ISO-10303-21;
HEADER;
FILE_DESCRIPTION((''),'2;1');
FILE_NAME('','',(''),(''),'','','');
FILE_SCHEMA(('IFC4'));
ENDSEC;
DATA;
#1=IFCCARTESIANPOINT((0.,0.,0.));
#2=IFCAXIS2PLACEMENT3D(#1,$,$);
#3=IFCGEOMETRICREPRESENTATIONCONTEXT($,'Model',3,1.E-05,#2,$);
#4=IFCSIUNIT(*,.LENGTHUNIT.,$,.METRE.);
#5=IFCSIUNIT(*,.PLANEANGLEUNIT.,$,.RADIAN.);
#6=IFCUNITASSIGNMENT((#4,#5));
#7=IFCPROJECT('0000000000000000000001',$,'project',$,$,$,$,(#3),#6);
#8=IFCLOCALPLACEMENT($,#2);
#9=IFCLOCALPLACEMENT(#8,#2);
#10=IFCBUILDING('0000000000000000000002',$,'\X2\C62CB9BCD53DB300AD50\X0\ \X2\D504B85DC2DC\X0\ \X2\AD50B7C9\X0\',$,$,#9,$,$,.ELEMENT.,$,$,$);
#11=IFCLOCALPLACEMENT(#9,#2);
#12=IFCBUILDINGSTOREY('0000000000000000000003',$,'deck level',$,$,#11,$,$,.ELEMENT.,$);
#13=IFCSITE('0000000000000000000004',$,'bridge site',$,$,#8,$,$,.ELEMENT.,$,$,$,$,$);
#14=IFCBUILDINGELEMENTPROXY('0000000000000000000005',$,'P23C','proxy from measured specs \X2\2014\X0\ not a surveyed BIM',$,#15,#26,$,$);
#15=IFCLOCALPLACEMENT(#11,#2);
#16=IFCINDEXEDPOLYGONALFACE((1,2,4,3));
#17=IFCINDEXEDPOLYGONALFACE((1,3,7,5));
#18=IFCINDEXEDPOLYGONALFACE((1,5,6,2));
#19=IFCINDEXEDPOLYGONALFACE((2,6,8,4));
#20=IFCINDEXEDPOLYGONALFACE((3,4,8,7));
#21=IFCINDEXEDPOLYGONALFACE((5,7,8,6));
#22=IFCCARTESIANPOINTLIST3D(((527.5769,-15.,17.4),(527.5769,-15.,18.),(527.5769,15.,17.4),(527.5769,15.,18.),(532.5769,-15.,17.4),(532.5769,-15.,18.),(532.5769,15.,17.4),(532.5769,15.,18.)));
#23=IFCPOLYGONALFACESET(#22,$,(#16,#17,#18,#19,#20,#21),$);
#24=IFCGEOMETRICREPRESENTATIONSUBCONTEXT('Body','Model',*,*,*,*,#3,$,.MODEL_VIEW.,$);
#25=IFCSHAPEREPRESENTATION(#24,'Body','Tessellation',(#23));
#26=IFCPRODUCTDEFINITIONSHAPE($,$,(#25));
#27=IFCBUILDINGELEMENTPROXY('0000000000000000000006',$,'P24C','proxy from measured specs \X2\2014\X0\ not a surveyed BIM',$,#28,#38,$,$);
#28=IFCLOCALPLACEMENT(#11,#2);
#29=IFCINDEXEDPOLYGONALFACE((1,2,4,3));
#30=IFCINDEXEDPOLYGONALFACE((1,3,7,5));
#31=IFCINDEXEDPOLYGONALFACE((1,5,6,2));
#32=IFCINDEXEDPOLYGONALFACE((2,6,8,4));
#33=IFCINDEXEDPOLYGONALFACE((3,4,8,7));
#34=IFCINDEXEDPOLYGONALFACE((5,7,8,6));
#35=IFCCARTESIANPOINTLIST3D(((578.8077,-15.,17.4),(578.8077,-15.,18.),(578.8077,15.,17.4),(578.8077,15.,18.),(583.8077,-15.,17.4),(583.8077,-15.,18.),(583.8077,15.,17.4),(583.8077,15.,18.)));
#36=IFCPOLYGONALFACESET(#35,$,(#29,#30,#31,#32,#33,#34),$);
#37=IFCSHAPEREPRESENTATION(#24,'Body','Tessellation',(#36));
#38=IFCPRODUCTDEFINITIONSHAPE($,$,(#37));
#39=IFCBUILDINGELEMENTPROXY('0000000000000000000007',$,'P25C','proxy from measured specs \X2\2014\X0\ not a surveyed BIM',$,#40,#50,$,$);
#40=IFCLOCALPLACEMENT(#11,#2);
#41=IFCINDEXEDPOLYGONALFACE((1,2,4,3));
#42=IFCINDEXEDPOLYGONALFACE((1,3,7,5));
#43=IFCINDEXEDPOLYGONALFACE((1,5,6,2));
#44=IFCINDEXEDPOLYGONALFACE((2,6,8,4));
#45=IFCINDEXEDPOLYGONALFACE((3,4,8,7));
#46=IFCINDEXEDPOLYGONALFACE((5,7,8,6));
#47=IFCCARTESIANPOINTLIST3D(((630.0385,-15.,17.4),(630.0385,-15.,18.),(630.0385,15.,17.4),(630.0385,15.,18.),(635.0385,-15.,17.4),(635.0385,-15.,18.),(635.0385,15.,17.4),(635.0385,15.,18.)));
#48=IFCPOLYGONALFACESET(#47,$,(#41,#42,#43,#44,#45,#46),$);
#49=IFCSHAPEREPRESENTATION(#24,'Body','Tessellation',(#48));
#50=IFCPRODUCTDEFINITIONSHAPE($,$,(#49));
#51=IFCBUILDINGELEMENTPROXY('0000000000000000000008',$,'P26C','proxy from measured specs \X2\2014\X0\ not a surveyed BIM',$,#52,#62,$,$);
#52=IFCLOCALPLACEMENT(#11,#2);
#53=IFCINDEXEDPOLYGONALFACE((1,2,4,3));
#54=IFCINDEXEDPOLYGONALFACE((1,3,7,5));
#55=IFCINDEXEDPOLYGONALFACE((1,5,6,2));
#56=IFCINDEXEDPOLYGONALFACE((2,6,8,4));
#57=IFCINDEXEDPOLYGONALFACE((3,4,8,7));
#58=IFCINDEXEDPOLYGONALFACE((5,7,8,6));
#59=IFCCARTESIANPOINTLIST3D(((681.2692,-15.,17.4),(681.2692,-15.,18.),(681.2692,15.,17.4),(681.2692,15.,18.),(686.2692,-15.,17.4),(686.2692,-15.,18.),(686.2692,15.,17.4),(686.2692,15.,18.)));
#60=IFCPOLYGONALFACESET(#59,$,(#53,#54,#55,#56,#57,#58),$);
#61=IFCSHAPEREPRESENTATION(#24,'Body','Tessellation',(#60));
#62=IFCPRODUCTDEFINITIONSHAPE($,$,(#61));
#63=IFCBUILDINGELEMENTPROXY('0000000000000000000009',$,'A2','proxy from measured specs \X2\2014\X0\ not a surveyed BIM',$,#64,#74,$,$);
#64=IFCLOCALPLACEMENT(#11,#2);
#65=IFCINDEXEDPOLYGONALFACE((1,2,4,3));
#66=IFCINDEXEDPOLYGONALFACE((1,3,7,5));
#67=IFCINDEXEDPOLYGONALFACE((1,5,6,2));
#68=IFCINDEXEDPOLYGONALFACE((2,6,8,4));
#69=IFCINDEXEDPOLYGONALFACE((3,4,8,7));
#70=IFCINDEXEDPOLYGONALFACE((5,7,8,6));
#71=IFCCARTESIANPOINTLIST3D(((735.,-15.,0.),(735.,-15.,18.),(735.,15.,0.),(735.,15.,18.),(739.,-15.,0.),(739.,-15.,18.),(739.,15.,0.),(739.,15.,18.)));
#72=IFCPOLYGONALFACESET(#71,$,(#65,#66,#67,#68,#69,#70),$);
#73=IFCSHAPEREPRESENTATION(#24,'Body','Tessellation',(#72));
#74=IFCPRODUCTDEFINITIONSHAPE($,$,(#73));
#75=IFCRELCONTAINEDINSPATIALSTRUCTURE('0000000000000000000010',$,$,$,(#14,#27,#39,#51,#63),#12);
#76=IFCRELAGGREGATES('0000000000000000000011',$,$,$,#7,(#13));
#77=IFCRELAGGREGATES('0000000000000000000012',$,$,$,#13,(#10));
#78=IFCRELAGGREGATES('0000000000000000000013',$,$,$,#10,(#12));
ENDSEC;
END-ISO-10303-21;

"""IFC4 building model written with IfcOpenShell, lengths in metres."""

from ifc_helpers import new_model, si_unit, frame, origin, origin_2d, place, context, subcontext, project, spatial, rectangle, extrude, element, save


model = new_model("IFC4")

# Units and contexts
model_context = context("Model", 3, precision=1e-05, world=origin())
body_context = subcontext(model_context, "Body", "Model", "MODEL_VIEW")
ifc_project = project(units=[si_unit("LENGTHUNIT", "METRE"), si_unit("PLANEANGLEUNIT", "RADIAN")], contexts=[model_context])

# Site, building, storey
site_placement = place(None, origin())
site = spatial("IfcSite", under=ifc_project, at=site_placement, Name="bridge site", CompositionType="ELEMENT")
building_placement = place(site_placement, origin())
building = spatial("IfcBuilding", under=site, at=building_placement, Name="올림픽대교 프록시 교량", CompositionType="ELEMENT")
storey_placement = place(building_placement, origin())
storey = spatial("IfcBuildingStorey", under=building, at=storey_placement, Name="deck level", CompositionType="ELEMENT")

# Building element proxies
for number, where, name in (
    (1, (530.0769, 0.0, 17.4), "P23C"),
    (2, (581.3077, 0.0, 17.4), "P24C"),
    (3, (632.5385, 0.0, 17.4), "P25C"),
    (4, (683.7692, 0.0, 17.4), "P26C"),
):
    element("IfcBuildingElementProxy", number, at=place(storey_placement, frame(where)), inside=storey, Name=name, Description="proxy from measured specs — not a surveyed BIM", context=body_context, shape_type="SweptSolid", body=[
        extrude(rectangle(XDim=5.0, YDim=30.0, at=origin_2d()), origin(), (0.0, 0.0, 1.0), 0.6),
    ])
proxy_placement = place(storey_placement, frame((737.0, 0.0, 0.0)))
element("IfcBuildingElementProxy", 5, at=proxy_placement, inside=storey, Name="A2", Description="proxy from measured specs — not a surveyed BIM", context=body_context, shape_type="SweptSolid", body=[
    extrude(rectangle(XDim=4.0, YDim=30.0, at=origin_2d()), origin(), (0.0, 0.0, 1.0), 18.0),
])

save(model, "model.ifc")
